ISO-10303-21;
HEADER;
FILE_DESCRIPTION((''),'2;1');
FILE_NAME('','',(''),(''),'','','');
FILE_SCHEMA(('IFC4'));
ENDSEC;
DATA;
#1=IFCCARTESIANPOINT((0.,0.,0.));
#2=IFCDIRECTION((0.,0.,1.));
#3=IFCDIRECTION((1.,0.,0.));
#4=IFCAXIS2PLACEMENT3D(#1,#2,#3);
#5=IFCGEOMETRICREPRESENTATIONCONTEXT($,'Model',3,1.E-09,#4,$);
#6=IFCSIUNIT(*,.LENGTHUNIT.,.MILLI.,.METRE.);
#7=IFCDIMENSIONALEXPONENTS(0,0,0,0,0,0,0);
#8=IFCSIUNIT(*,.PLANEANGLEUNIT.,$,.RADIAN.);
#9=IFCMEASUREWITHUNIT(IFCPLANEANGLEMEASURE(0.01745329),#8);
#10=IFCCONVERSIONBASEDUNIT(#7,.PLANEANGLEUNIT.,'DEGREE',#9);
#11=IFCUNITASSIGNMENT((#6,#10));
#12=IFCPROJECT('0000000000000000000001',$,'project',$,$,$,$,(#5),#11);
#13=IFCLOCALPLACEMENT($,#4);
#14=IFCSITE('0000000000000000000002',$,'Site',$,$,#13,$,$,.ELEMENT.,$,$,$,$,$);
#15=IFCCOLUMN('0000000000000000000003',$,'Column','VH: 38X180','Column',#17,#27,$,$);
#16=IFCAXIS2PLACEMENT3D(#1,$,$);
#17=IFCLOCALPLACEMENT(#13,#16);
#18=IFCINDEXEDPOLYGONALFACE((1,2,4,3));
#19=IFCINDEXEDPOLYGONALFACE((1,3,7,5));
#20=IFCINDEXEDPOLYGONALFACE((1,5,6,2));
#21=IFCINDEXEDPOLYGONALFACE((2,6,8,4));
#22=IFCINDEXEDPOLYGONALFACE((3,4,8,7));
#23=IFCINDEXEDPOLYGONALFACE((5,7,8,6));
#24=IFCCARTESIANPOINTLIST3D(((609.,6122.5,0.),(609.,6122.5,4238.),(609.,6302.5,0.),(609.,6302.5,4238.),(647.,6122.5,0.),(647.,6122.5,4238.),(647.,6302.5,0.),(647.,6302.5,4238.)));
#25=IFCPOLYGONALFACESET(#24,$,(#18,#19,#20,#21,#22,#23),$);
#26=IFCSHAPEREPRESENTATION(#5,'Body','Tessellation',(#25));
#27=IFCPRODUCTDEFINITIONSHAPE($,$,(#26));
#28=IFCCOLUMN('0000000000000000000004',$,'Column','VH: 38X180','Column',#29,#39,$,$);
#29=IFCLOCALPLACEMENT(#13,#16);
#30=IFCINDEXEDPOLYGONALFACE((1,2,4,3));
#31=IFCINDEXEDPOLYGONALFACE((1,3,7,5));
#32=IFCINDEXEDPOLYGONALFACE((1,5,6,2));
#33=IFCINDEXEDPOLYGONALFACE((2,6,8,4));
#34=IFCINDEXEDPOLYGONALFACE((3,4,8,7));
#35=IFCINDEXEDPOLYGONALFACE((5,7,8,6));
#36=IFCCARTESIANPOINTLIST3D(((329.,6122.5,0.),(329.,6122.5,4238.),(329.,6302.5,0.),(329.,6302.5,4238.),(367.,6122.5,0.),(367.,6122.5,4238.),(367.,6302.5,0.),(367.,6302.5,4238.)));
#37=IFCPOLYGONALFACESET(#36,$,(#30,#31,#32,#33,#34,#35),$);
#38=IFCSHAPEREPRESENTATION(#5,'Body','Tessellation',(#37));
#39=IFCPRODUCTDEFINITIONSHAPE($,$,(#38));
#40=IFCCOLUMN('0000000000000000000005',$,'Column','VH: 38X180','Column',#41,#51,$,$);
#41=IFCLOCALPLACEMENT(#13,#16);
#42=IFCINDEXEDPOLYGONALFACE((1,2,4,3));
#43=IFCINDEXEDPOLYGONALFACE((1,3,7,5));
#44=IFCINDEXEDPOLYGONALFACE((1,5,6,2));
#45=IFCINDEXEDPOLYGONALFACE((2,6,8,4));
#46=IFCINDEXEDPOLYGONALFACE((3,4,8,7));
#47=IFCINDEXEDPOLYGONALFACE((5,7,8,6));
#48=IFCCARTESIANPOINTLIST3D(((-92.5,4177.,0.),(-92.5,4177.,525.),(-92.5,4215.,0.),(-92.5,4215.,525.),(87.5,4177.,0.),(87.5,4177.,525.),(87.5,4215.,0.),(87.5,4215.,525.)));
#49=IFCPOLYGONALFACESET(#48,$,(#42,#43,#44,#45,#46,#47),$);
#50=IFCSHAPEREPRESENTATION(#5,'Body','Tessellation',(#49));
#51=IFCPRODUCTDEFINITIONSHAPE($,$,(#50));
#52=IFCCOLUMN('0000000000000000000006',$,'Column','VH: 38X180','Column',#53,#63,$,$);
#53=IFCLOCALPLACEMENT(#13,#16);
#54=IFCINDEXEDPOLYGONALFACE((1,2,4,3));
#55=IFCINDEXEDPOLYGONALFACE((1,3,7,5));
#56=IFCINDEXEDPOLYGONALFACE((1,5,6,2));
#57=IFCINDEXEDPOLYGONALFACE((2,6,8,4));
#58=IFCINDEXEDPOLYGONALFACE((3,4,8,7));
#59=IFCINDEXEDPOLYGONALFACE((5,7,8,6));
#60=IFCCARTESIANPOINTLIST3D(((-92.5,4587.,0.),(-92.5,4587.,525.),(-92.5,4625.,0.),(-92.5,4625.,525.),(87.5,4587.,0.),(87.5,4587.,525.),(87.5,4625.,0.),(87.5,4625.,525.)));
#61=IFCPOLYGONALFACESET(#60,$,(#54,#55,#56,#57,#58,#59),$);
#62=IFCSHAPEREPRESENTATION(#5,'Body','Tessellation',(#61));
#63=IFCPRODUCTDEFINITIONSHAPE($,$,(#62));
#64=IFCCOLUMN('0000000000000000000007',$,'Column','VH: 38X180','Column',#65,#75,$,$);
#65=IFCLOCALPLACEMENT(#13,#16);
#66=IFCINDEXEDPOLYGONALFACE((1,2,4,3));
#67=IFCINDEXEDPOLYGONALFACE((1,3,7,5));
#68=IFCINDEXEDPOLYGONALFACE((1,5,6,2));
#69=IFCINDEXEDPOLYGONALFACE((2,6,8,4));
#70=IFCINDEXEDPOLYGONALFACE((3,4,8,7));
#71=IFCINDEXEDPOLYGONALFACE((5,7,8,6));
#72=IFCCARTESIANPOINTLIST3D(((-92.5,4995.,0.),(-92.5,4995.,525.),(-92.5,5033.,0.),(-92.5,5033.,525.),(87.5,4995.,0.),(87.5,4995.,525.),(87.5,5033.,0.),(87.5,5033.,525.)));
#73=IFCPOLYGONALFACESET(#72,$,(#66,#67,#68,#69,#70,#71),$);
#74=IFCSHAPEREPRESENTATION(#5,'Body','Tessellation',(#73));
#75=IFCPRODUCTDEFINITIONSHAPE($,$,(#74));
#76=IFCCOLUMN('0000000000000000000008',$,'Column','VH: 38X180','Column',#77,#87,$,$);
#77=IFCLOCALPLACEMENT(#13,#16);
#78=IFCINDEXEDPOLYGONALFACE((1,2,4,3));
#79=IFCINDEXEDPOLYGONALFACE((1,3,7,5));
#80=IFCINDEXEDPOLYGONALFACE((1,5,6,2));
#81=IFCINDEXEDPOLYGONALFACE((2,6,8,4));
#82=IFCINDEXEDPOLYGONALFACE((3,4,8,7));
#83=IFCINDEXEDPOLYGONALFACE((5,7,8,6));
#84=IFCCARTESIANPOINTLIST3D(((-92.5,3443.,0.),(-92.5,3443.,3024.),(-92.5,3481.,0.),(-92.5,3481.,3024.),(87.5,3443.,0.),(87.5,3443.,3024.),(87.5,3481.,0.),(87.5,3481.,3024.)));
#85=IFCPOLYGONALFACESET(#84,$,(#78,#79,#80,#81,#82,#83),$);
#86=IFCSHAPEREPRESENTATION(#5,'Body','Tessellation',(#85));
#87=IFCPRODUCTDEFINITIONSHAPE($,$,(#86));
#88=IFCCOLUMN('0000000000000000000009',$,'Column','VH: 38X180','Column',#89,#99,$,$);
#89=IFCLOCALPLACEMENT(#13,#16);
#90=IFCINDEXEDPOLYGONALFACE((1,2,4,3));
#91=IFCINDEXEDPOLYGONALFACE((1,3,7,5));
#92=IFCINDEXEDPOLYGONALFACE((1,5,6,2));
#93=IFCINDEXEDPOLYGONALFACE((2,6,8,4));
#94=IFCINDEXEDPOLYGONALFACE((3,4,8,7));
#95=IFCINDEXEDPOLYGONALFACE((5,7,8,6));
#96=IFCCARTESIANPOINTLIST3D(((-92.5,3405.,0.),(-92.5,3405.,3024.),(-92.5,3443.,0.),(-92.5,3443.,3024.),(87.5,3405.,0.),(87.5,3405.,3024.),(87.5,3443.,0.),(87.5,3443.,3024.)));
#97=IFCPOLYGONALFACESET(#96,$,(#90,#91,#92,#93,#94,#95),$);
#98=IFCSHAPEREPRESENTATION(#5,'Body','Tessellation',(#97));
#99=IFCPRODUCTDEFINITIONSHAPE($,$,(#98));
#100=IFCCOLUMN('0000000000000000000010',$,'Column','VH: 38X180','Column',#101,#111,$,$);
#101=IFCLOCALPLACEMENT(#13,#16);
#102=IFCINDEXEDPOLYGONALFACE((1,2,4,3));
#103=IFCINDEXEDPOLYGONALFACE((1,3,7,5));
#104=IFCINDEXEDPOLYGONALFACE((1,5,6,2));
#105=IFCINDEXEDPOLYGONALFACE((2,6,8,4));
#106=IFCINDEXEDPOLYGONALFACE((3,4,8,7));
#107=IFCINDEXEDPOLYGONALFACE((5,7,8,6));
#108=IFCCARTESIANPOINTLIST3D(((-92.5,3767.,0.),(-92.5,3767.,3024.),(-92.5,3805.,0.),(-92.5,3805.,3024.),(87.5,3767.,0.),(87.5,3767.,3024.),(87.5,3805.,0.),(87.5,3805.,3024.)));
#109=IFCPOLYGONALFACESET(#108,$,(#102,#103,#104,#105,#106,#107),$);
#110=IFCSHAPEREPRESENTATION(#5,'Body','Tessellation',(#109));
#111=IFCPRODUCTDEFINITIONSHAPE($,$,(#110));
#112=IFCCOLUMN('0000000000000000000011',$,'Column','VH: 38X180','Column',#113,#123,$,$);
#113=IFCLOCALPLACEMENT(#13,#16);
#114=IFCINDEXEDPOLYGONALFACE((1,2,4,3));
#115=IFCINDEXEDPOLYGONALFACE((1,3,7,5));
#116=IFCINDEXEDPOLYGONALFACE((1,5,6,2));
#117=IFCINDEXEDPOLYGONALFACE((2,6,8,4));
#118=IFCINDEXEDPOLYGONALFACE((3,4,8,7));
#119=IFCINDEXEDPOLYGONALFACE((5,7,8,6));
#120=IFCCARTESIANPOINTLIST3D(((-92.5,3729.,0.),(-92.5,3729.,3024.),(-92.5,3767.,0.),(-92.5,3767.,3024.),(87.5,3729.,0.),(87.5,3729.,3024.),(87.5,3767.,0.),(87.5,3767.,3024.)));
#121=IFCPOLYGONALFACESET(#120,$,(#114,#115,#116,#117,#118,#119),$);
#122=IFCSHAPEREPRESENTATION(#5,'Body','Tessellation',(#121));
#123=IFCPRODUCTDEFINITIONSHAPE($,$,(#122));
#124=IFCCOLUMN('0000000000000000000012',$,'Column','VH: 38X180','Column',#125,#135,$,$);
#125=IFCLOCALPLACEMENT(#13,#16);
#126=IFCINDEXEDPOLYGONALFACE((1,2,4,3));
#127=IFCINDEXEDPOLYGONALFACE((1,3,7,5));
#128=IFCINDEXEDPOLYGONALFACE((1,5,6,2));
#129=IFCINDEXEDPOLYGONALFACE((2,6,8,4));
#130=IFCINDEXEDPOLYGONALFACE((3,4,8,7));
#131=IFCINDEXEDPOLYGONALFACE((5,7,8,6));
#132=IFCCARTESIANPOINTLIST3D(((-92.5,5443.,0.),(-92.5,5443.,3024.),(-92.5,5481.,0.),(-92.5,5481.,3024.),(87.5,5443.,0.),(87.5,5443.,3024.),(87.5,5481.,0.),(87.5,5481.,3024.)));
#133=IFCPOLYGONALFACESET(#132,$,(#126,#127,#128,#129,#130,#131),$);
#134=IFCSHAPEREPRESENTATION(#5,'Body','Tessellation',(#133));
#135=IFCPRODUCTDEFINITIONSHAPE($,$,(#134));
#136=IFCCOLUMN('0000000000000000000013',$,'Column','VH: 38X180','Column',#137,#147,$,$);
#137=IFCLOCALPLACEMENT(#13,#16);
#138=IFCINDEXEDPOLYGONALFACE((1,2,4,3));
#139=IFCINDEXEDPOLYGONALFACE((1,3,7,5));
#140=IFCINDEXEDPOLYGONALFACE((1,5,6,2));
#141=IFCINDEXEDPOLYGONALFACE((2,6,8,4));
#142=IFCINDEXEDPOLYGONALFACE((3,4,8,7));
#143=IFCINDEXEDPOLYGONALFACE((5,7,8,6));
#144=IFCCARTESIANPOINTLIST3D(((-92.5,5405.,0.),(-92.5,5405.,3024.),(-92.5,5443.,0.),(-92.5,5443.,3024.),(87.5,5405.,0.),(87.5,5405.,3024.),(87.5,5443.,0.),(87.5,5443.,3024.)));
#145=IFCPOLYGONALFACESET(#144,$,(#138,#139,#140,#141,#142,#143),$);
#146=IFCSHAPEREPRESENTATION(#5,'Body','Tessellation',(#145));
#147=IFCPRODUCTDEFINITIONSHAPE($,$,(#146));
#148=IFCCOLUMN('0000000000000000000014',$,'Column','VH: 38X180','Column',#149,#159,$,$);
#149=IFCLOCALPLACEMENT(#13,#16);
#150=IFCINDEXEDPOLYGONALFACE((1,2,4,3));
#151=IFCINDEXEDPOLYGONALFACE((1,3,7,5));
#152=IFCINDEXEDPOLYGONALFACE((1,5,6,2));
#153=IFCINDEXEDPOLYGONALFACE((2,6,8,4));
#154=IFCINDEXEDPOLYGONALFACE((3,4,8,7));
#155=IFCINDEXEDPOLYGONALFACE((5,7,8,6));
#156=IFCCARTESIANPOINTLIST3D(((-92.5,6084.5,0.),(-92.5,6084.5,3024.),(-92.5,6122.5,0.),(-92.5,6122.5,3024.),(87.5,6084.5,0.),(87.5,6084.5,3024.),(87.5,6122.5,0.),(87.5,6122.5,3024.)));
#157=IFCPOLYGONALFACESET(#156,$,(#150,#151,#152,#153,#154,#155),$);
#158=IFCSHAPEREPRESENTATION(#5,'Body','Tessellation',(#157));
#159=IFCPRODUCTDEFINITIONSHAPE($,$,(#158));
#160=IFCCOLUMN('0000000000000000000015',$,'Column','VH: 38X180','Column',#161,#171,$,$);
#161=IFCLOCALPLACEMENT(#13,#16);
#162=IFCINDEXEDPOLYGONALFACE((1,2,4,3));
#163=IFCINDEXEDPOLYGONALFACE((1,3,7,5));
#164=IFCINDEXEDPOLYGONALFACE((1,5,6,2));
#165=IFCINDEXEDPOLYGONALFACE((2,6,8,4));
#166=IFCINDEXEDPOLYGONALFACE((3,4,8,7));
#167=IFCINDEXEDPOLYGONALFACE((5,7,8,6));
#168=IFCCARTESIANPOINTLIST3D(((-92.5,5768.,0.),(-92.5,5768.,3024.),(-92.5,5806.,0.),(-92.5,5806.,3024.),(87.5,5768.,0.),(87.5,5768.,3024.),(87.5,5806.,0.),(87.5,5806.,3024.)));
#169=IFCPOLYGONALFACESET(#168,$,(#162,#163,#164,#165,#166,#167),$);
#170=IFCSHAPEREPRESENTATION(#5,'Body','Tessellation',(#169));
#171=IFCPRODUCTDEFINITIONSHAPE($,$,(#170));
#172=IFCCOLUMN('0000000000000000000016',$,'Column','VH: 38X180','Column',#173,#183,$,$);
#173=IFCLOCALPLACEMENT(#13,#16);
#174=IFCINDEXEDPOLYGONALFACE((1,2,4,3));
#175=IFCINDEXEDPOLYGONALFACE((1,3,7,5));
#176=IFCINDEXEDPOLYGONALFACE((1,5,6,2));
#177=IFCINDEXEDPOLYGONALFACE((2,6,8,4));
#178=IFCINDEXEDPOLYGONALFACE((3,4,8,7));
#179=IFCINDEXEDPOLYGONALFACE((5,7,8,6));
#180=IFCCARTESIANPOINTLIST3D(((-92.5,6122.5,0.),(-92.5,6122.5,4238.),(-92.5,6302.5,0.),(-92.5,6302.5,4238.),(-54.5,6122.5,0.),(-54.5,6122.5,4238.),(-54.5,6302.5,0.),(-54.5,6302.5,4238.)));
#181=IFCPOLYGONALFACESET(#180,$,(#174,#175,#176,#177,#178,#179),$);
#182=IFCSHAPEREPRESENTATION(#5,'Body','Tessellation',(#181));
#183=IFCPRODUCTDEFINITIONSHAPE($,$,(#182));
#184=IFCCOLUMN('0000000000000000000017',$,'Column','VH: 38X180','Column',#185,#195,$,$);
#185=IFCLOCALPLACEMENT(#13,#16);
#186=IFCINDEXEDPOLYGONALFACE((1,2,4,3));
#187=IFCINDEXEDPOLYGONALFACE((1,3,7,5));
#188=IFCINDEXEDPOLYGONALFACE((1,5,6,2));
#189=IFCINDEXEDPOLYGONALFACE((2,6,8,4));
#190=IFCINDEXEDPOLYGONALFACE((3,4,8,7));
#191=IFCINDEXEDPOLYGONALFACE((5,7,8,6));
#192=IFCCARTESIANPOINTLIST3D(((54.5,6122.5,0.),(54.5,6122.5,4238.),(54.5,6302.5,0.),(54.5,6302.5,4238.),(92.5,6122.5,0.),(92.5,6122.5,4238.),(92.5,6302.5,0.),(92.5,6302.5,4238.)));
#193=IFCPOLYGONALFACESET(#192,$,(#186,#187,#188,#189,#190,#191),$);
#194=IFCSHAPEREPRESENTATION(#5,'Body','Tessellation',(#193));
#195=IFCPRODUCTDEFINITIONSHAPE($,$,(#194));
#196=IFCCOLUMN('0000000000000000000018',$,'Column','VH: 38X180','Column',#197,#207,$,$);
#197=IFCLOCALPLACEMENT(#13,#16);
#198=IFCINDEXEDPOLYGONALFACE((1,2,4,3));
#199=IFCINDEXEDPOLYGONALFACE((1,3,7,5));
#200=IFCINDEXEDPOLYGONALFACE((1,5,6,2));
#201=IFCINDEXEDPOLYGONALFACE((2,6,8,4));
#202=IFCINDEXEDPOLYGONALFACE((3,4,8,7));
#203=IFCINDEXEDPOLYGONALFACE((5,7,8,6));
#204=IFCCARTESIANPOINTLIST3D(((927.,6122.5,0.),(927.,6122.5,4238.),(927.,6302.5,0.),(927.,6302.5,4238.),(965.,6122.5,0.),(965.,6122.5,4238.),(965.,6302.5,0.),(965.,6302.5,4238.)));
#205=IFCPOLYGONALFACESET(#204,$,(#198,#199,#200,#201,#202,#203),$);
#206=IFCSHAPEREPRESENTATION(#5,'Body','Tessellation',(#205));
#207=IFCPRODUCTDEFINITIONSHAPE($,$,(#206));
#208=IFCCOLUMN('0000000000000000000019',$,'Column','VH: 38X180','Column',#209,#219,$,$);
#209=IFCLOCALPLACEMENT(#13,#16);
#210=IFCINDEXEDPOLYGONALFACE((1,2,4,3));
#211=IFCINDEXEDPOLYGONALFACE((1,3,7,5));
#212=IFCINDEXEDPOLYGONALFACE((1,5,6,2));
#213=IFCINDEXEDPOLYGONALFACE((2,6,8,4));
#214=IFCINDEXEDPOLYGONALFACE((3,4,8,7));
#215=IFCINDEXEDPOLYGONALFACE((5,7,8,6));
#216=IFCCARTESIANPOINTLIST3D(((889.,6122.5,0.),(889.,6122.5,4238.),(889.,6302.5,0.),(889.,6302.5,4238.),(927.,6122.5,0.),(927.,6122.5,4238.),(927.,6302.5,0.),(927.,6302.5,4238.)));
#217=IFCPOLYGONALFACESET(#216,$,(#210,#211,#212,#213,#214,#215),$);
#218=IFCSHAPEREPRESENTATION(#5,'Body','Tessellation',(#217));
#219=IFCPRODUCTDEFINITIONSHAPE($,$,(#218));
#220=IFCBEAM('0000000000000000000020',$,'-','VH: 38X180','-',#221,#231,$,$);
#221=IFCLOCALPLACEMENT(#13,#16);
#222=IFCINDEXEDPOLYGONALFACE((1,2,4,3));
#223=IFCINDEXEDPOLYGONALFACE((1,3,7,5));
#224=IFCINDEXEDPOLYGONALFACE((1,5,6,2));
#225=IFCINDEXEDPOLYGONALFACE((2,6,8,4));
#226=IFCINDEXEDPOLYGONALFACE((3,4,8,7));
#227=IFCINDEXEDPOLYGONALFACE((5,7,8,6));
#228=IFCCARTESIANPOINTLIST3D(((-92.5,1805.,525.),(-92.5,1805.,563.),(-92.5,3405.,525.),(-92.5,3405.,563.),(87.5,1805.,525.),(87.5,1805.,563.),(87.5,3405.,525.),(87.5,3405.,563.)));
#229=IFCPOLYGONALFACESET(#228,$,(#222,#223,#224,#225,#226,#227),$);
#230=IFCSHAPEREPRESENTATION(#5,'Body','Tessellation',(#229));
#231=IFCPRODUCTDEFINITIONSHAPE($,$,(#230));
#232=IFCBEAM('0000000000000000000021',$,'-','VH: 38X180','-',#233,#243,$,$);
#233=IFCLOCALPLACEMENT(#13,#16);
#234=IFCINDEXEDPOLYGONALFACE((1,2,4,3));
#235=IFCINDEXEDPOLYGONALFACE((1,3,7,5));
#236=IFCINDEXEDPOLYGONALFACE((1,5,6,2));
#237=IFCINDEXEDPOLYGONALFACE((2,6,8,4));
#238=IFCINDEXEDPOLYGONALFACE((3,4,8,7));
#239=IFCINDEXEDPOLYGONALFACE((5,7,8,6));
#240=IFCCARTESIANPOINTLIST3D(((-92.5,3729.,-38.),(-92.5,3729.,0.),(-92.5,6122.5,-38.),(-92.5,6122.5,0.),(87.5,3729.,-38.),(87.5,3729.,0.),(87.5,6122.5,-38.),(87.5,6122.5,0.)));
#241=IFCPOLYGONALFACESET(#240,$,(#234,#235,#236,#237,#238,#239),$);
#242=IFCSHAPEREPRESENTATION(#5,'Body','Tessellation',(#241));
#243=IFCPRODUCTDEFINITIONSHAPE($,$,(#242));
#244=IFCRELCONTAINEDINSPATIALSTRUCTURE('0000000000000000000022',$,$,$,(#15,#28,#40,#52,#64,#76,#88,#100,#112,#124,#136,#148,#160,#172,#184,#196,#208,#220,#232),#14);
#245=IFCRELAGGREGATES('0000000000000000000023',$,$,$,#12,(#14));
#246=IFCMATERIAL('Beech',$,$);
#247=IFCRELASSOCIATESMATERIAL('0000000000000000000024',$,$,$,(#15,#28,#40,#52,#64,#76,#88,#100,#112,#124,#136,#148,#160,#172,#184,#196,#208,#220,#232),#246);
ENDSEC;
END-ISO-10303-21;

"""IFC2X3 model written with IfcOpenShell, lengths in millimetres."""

from ifc_helpers import new_model, entity, si_unit, converted_unit, frame, origin, origin_with_axes, origin_2d, place, context, project, spatial, rectangle, extrude, material, element, save


model = new_model("IFC2X3")

# Units and contexts
model_context = context("Model", 3, precision=1e-09, world=origin_with_axes())
ifc_project = project(units=[si_unit("LENGTHUNIT", "METRE", prefix="MILLI"), converted_unit("PLANEANGLEUNIT", "DEGREE", entity("IfcPlaneAngleMeasure", 0.01745329), si_unit("PLANEANGLEUNIT", "RADIAN"), dimensions=[0, 0, 0, 0, 0, 0, 0])], contexts=[model_context])

# Site
site_placement = place(None, origin_with_axes())
site = spatial("IfcSite", under=ifc_project, at=site_placement, Name="Site", CompositionType="ELEMENT")

# Columns
ifc_material_1 = material(Name="Beech")
for number, where, z_axis, x_axis, name in (
    (1, (628.0, 6212.5, 0.0), (0.0, 0.0, -1.0), (-1.0, 0.0, 0.0), "Column"),
    (2, (348.0, 6212.5, 0.0), (0.0, 0.0, -1.0), (-1.0, 0.0, 0.0), "Column"),
):
    element("IfcColumn", number, at=place(None, frame(where, z_axis=z_axis, x_axis=x_axis)), inside=site, material=ifc_material_1, Name=name, Description="VH: 38X180", ObjectType="Column", context=model_context, shape_type="SweptSolid", body=[
        extrude(rectangle(XDim=38.0, YDim=180.0, at=origin_2d()), origin(), (0.0, 0.0, -1.0), 4238.0),
    ])
for number, where, z_axis, x_axis, name in (
    (3, (-2.5, 4196.0, 0.0), (0.0, 0.0, -1.0), (0.0, -1.0, 0.0), "Column"),
    (4, (-2.5, 4606.0, 0.0), (0.0, 0.0, -1.0), (0.0, -1.0, 0.0), "Column"),
    (5, (-2.5, 5014.0, 0.0), (0.0, 0.0, -1.0), (0.0, -1.0, 0.0), "Column"),
):
    element("IfcColumn", number, at=place(None, frame(where, z_axis=z_axis, x_axis=x_axis)), inside=site, material=ifc_material_1, Name=name, Description="VH: 38X180", ObjectType="Column", context=model_context, shape_type="SweptSolid", body=[
        extrude(rectangle(XDim=38.0, YDim=180.0, at=origin_2d()), origin(), (0.0, 0.0, -1.0), 525.0),
    ])
for number, where, z_axis, x_axis, name in (
    (6, (-2.5, 3462.0, 0.0), (0.0, 0.0, -1.0), (0.0, -1.0, 0.0), "Column"),
    (7, (-2.5, 3424.0, 0.0), (0.0, 0.0, -1.0), (0.0, -1.0, 0.0), "Column"),
    (8, (-2.5, 3786.0, 0.0), (0.0, 0.0, -1.0), (0.0, -1.0, 0.0), "Column"),
    (9, (-2.5, 3748.0, 0.0), (0.0, 0.0, -1.0), (0.0, -1.0, 0.0), "Column"),
    (10, (-2.5, 5462.0, 0.0), (0.0, 0.0, -1.0), (0.0, -1.0, 0.0), "Column"),
    (11, (-2.5, 5424.0, 0.0), (0.0, 0.0, -1.0), (0.0, -1.0, 0.0), "Column"),
    (12, (-2.5, 6103.5, 0.0), (0.0, 0.0, -1.0), (0.0, -1.0, 0.0), "Column"),
    (13, (-2.5, 5787.0, 0.0), (0.0, 0.0, -1.0), (0.0, -1.0, 0.0), "Column"),
):
    element("IfcColumn", number, at=place(None, frame(where, z_axis=z_axis, x_axis=x_axis)), inside=site, material=ifc_material_1, Name=name, Description="VH: 38X180", ObjectType="Column", context=model_context, shape_type="SweptSolid", body=[
        extrude(rectangle(XDim=38.0, YDim=180.0, at=origin_2d()), origin(), (0.0, 0.0, -1.0), 3024.0),
    ])
for number, where, z_axis, x_axis, name in (
    (14, (-73.5, 6212.5, 0.0), (0.0, 0.0, -1.0), (-1.0, 0.0, 0.0), "Column"),
    (15, (73.5, 6212.5, 0.0), (0.0, 0.0, -1.0), (-1.0, 0.0, 0.0), "Column"),
    (16, (946.0, 6212.5, 0.0), (0.0, 0.0, -1.0), (-1.0, 0.0, 0.0), "Column"),
    (17, (908.0, 6212.5, 0.0), (0.0, 0.0, -1.0), (-1.0, 0.0, 0.0), "Column"),
):
    element("IfcColumn", number, at=place(None, frame(where, z_axis=z_axis, x_axis=x_axis)), inside=site, material=ifc_material_1, Name=name, Description="VH: 38X180", ObjectType="Column", context=model_context, shape_type="SweptSolid", body=[
        extrude(rectangle(XDim=38.0, YDim=180.0, at=origin_2d()), origin(), (0.0, 0.0, -1.0), 4238.0),
    ])

# Beams
beam_placement = place(None, frame((-2.5, 3405.0, 544.0), z_axis=(0.0, -1.0, 0.0), x_axis=(0.0, 0.0, 1.0)))
element("IfcBeam", 18, at=beam_placement, inside=site, material=ifc_material_1, Name="-", Description="VH: 38X180", ObjectType="-", context=model_context, shape_type="SweptSolid", body=[
    extrude(rectangle(XDim=38.0, YDim=180.0, at=origin_2d()), origin(), (0.0, 0.0, 1.0), 1600.0),
])
for number, where, z_axis, x_axis, name in (
    (19, (-2.5, 6122.5, -19.0), (0.0, -1.0, 0.0), (0.0, 0.0, 1.0), "-"),
):
    element("IfcBeam", number, at=place(None, frame(where, z_axis=z_axis, x_axis=x_axis)), inside=site, material=ifc_material_1, Name=name, Description="VH: 38X180", ObjectType="-", context=model_context, shape_type="SweptSolid", body=[
        extrude(rectangle(XDim=38.0, YDim=180.0, at=origin_2d()), origin(), (0.0, 0.0, 1.0), 2393.5),
    ])

save(model, "model.ifc")
